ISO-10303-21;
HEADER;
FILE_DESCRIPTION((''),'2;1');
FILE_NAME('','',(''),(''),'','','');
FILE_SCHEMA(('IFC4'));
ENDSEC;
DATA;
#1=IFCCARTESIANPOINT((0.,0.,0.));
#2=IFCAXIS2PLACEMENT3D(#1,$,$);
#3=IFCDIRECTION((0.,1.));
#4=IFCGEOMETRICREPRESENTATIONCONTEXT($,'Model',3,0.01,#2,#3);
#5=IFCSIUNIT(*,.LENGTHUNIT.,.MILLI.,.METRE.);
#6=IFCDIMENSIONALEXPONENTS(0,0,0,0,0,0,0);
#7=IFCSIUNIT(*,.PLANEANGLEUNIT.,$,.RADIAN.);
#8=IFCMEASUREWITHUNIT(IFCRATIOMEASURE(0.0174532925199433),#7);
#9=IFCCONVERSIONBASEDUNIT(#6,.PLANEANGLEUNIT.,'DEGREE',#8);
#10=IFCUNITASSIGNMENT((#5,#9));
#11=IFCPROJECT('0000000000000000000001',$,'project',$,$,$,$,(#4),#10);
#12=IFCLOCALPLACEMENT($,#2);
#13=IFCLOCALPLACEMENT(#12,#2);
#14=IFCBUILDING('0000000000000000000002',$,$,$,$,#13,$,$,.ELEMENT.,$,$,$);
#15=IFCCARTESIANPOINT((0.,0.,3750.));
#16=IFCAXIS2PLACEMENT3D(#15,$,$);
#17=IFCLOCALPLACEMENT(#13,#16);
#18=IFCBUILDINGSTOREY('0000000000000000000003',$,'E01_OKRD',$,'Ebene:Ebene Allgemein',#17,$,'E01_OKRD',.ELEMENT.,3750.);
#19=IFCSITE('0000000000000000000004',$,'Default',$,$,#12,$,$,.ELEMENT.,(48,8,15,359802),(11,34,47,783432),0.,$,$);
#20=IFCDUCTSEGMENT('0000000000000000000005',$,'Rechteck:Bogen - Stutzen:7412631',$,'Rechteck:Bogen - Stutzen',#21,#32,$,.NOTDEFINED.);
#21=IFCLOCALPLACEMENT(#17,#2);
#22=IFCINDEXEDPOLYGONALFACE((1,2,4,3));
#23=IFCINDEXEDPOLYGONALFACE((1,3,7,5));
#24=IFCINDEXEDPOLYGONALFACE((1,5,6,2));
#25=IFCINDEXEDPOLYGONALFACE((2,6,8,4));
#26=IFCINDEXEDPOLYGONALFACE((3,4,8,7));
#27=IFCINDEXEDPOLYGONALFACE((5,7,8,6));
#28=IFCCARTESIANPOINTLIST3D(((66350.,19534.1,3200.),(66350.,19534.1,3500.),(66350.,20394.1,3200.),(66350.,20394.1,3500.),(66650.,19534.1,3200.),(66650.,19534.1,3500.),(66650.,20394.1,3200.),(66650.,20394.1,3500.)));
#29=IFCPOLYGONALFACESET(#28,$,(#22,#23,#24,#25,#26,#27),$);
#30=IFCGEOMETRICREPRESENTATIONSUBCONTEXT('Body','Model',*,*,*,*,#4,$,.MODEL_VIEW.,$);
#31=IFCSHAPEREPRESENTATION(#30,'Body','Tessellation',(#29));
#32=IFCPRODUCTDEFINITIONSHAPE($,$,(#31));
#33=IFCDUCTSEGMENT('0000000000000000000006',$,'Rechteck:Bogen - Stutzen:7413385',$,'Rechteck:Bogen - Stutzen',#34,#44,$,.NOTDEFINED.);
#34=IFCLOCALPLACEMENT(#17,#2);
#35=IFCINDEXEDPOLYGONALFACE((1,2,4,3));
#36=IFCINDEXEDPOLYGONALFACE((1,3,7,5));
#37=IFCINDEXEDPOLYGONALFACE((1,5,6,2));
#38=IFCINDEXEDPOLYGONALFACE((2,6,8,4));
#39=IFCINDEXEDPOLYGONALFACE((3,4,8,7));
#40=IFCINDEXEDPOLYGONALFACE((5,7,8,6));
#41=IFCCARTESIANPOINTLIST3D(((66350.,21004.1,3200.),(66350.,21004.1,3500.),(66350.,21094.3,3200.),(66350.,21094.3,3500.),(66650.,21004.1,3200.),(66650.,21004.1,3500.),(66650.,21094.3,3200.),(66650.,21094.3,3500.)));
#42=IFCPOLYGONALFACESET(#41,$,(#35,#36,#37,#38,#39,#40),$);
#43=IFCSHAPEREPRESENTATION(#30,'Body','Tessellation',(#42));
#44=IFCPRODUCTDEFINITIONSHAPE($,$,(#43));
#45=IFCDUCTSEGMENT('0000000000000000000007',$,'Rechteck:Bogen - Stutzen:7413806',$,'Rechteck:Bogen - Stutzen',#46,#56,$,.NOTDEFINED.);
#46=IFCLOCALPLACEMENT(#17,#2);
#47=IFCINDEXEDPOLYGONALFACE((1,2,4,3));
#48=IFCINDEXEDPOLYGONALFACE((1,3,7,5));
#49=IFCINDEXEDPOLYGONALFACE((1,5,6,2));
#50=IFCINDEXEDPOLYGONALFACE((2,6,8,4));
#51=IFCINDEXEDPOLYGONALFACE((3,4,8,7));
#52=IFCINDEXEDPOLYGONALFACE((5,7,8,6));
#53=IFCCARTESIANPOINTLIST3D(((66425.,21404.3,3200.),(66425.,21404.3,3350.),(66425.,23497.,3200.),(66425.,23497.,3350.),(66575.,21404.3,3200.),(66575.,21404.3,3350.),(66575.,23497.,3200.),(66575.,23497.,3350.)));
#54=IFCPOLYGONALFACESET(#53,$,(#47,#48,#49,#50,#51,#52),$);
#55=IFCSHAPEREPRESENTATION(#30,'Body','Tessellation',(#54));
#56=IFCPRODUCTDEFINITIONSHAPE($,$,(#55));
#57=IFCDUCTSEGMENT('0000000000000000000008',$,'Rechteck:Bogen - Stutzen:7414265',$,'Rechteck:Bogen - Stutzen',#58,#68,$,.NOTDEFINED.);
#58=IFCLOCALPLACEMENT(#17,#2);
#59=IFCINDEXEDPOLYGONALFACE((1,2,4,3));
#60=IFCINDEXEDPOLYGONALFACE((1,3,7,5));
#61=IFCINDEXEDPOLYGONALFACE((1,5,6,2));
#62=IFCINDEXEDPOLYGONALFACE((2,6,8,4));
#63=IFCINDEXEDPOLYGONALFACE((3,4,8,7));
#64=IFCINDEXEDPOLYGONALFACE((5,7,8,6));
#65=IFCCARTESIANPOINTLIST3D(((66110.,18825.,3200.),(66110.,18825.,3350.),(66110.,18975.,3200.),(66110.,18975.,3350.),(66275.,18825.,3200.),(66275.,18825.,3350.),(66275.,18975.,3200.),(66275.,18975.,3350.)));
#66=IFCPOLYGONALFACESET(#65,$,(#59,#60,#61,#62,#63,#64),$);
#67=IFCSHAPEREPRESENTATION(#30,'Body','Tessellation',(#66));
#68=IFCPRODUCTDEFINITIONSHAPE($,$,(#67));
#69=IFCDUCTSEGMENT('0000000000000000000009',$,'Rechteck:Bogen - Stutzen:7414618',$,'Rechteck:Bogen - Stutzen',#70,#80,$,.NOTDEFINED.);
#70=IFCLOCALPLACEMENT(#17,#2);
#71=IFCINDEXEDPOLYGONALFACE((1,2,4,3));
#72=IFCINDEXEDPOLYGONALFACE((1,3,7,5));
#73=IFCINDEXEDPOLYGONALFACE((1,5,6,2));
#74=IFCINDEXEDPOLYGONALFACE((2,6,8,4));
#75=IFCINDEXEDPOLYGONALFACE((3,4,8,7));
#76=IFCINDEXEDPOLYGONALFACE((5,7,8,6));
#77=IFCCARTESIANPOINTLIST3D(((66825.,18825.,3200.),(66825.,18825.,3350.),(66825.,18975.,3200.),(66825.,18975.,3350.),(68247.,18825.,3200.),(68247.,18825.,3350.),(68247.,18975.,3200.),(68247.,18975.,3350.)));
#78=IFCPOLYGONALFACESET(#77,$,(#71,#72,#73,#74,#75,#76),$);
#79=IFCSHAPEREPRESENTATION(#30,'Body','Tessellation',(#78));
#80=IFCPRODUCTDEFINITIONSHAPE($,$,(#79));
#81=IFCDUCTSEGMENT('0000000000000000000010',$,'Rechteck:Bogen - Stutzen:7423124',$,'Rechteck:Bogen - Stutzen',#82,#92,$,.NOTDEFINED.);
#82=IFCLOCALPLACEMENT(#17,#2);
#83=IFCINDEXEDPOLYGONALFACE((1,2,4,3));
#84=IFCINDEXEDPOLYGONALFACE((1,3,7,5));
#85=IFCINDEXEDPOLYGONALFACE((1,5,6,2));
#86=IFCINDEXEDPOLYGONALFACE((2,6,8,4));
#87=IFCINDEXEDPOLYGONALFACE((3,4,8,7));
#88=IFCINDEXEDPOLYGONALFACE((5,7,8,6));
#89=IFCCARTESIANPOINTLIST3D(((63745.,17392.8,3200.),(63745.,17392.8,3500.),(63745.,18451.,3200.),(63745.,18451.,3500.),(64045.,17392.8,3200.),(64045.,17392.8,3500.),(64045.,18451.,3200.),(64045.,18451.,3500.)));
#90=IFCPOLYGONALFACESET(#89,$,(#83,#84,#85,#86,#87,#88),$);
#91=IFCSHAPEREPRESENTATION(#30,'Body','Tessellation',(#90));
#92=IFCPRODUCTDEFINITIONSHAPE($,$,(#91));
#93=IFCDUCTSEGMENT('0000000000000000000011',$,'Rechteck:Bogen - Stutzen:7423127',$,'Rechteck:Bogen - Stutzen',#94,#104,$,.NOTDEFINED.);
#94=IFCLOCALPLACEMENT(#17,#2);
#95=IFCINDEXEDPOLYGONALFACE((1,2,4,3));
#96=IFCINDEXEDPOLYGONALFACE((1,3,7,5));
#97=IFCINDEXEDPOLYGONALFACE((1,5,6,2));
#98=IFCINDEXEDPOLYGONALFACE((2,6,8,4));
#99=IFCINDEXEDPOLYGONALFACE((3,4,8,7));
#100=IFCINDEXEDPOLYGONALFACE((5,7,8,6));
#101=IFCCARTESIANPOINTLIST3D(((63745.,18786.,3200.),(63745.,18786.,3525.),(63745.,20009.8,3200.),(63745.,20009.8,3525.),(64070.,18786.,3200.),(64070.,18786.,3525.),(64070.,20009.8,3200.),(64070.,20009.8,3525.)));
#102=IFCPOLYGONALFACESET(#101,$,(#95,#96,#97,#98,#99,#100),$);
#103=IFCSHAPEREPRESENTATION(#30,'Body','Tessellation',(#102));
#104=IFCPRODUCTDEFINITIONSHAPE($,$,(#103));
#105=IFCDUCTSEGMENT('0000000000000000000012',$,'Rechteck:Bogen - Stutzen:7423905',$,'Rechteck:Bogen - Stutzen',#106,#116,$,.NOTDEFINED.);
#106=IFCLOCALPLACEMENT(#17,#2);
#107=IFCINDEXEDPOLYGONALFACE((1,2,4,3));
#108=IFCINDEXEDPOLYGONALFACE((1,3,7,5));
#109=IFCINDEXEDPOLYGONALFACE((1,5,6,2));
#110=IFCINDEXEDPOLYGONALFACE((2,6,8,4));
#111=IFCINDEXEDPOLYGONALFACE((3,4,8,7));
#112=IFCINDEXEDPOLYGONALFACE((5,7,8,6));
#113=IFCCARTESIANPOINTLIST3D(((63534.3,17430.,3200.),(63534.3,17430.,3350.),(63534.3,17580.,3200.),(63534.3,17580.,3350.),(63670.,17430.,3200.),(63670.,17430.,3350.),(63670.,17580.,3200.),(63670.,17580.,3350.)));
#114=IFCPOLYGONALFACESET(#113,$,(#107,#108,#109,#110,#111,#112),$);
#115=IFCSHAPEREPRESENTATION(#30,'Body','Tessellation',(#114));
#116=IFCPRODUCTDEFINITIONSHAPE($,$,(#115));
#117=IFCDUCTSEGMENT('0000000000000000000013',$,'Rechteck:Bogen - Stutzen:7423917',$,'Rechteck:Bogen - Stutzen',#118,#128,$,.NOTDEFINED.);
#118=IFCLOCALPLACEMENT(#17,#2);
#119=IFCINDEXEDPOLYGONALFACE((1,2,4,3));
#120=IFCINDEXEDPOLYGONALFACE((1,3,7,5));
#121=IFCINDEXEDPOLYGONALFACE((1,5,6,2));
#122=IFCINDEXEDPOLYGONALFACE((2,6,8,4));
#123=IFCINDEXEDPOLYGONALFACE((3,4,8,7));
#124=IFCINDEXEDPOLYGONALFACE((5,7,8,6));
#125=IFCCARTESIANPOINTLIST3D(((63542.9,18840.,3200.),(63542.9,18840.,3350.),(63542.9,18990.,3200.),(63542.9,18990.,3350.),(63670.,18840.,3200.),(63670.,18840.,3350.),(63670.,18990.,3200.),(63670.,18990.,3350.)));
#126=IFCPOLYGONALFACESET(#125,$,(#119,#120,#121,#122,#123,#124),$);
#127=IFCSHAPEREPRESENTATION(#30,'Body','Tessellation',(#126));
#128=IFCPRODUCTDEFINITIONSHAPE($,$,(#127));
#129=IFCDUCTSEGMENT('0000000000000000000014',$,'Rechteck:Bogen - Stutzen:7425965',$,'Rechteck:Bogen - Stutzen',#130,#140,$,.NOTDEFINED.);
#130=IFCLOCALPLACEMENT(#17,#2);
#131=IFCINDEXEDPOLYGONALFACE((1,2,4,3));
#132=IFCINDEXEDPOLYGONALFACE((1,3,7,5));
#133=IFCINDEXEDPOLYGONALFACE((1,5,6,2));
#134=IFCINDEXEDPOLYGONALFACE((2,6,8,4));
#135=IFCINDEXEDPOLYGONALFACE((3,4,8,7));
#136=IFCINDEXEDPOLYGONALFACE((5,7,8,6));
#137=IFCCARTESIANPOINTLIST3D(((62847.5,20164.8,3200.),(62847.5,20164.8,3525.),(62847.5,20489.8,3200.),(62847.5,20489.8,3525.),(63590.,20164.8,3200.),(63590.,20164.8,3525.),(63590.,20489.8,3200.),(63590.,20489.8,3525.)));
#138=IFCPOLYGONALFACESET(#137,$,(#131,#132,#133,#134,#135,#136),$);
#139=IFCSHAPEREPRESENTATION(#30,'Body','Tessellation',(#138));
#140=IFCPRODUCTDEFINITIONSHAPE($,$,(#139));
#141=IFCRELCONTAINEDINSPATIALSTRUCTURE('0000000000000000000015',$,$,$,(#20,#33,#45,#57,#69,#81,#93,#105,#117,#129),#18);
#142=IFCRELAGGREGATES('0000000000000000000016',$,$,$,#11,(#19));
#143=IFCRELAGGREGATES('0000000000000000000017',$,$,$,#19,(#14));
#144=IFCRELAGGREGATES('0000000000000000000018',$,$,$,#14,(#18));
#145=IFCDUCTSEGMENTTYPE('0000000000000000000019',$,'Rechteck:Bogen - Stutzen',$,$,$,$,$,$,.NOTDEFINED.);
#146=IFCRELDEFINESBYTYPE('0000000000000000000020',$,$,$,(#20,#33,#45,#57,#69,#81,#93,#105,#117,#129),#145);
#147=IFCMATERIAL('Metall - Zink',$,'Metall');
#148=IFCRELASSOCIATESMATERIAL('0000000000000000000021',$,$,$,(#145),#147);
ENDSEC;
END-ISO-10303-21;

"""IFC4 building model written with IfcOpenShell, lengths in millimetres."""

from ifc_helpers import new_model, entity, si_unit, converted_unit, direction, frame, frame_2d, origin, origin_2d_with_axis, place, context, subcontext, project, spatial, rectangle, extrude, material, type_object, element, save


model = new_model("IFC4")

# Units and contexts
model_context = context("Model", 3, precision=0.01, world=origin(), true_north=direction((0.0, 1.0)))
body_context = subcontext(model_context, "Body", "Model", "MODEL_VIEW")
ifc_project = project(units=[si_unit("LENGTHUNIT", "METRE", prefix="MILLI"), converted_unit("PLANEANGLEUNIT", "DEGREE", entity("IfcRatioMeasure", 0.0174532925199433), si_unit("PLANEANGLEUNIT", "RADIAN"), dimensions=[0, 0, 0, 0, 0, 0, 0])], contexts=[model_context])

# Site, building, storey
site_placement = place(None, origin())
site = spatial("IfcSite", under=ifc_project, at=site_placement, Name="Default", CompositionType="ELEMENT", RefLatitude=(48, 8, 15, 359802), RefLongitude=(11, 34, 47, 783432), RefElevation=0.0)
building_placement = place(site_placement, origin())
building = spatial("IfcBuilding", under=site, at=building_placement, CompositionType="ELEMENT")
storey_placement = place(building_placement, frame((0.0, 0.0, 3750.0)))
storey = spatial("IfcBuildingStorey", under=building, at=storey_placement, Name="E01_OKRD", ObjectType="Ebene:Ebene Allgemein", LongName="E01_OKRD", CompositionType="ELEMENT", Elevation=3750.0)

# Duct segments
ifc_material_1 = material(Name="Metall - Zink", Category="Metall")
duct_segment_type_1 = type_object("IfcDuctSegmentType", Name="Rechteck:Bogen - Stutzen", PredefinedType="NOTDEFINED", material=ifc_material_1)
duct_segment_1_placement = place(storey_placement, frame((66350.0, 19534.1, 3200.0)))
element("IfcDuctSegment", 1, at=duct_segment_1_placement, inside=storey, type_object=duct_segment_type_1, Name="Rechteck:Bogen - Stutzen:7412631", ObjectType="Rechteck:Bogen - Stutzen", PredefinedType="NOTDEFINED", context=body_context, shape_type="SweptSolid", body=[
    extrude(rectangle(XDim=860.0, YDim=300.0, at=frame_2d((0.0, 0.0), x_axis=(1.0, 0.0))), frame((150.0, 430.0, 0.0), z_axis=(0.0, 0.0, 1.0), x_axis=(0.0, -1.0, 0.0)), (0.0, 0.0, 1.0), 300.0),
])
duct_segment_2_placement = place(storey_placement, frame((66350.0, 21004.1, 3200.0)))
element("IfcDuctSegment", 2, at=duct_segment_2_placement, inside=storey, type_object=duct_segment_type_1, Name="Rechteck:Bogen - Stutzen:7413385", ObjectType="Rechteck:Bogen - Stutzen", PredefinedType="NOTDEFINED", context=body_context, shape_type="SweptSolid", body=[
    extrude(rectangle(XDim=90.2, YDim=300.0, at=frame_2d((0.0, 0.0), x_axis=(1.0, 0.0))), frame((150.0, 45.1, 0.0), z_axis=(0.0, 0.0, 1.0), x_axis=(0.0, 1.0, 0.0)), (0.0, 0.0, 1.0), 300.0),
])
duct_segment_3_placement = place(storey_placement, frame((66425.0, 21404.3, 3200.0)))
element("IfcDuctSegment", 3, at=duct_segment_3_placement, inside=storey, type_object=duct_segment_type_1, Name="Rechteck:Bogen - Stutzen:7413806", ObjectType="Rechteck:Bogen - Stutzen", PredefinedType="NOTDEFINED", context=body_context, shape_type="SweptSolid", body=[
    extrude(rectangle(XDim=2092.7, YDim=150.0, at=frame_2d((0.0, 0.0), x_axis=(1.0, 0.0))), frame((75.0, 1046.4, 0.0), z_axis=(0.0, 0.0, 1.0), x_axis=(0.0, -1.0, 0.0)), (0.0, 0.0, 1.0), 150.0),
])
duct_segment_4_placement = place(storey_placement, frame((66110.0, 18825.0, 3200.0)))
element("IfcDuctSegment", 4, at=duct_segment_4_placement, inside=storey, type_object=duct_segment_type_1, Name="Rechteck:Bogen - Stutzen:7414265", ObjectType="Rechteck:Bogen - Stutzen", PredefinedType="NOTDEFINED", context=body_context, shape_type="SweptSolid", body=[
    extrude(rectangle(XDim=165.0, YDim=150.0, at=origin_2d_with_axis()), frame((82.5, 75.0, 0.0), z_axis=(0.0, 0.0, 1.0), x_axis=(-1.0, 0.0, 0.0)), (0.0, 0.0, 1.0), 150.0),
])
duct_segment_5_placement = place(storey_placement, frame((66825.0, 18825.0, 3200.0)))
element("IfcDuctSegment", 5, at=duct_segment_5_placement, inside=storey, type_object=duct_segment_type_1, Name="Rechteck:Bogen - Stutzen:7414618", ObjectType="Rechteck:Bogen - Stutzen", PredefinedType="NOTDEFINED", context=body_context, shape_type="SweptSolid", body=[
    extrude(rectangle(XDim=1422.0, YDim=150.0, at=frame_2d((0.0, 0.0), x_axis=(1.0, 0.0))), frame((711.0, 75.0, 0.0), z_axis=(-0.000013, 0.0, 1.0), x_axis=(-1.0, 0.0, -0.000013)), (0.0, 0.0, 1.0), 150.0),
])
duct_segment_6_placement = place(storey_placement, frame((63745.0, 17392.8, 3200.0)))
element("IfcDuctSegment", 6, at=duct_segment_6_placement, inside=storey, type_object=duct_segment_type_1, Name="Rechteck:Bogen - Stutzen:7423124", ObjectType="Rechteck:Bogen - Stutzen", PredefinedType="NOTDEFINED", context=body_context, shape_type="SweptSolid", body=[
    extrude(rectangle(XDim=1058.2, YDim=300.0, at=frame_2d((0.0, 0.0), x_axis=(1.0, 0.0))), frame((150.0, 529.1, 0.0), z_axis=(0.0, 0.0, 1.0), x_axis=(0.0, -1.0, 0.0)), (0.0, 0.0, 1.0), 300.0),
])
duct_segment_7_placement = place(storey_placement, frame((63745.0, 18786.0, 3200.0)))
element("IfcDuctSegment", 7, at=duct_segment_7_placement, inside=storey, type_object=duct_segment_type_1, Name="Rechteck:Bogen - Stutzen:7423127", ObjectType="Rechteck:Bogen - Stutzen", PredefinedType="NOTDEFINED", context=body_context, shape_type="SweptSolid", body=[
    extrude(rectangle(XDim=1223.8, YDim=325.0, at=frame_2d((0.0, 0.0), x_axis=(1.0, 0.0))), frame((162.5, 611.9, 0.0), z_axis=(0.0, 0.0, 1.0), x_axis=(0.0, 1.0, 0.0)), (0.0, 0.0, 1.0), 325.0),
])
duct_segment_8_placement = place(storey_placement, frame((63534.3, 17430.0, 3200.0)))
element("IfcDuctSegment", 8, at=duct_segment_8_placement, inside=storey, type_object=duct_segment_type_1, Name="Rechteck:Bogen - Stutzen:7423905", ObjectType="Rechteck:Bogen - Stutzen", PredefinedType="NOTDEFINED", context=body_context, shape_type="SweptSolid", body=[
    extrude(rectangle(XDim=135.7, YDim=150.0, at=origin_2d_with_axis()), frame((67.8, 75.0, 0.0)), (0.0, 0.0, 1.0), 150.0),
])
duct_segment_9_placement = place(storey_placement, frame((63542.9, 18840.0, 3200.0)))
element("IfcDuctSegment", 9, at=duct_segment_9_placement, inside=storey, type_object=duct_segment_type_1, Name="Rechteck:Bogen - Stutzen:7423917", ObjectType="Rechteck:Bogen - Stutzen", PredefinedType="NOTDEFINED", context=body_context, shape_type="SweptSolid", body=[
    extrude(rectangle(XDim=127.1, YDim=150.0, at=origin_2d_with_axis()), frame((63.5, 75.0, 0.0)), (0.0, 0.0, 1.0), 150.0),
])
duct_segment_10_placement = place(storey_placement, frame((62847.5, 20164.8, 3200.0)))
element("IfcDuctSegment", 10, at=duct_segment_10_placement, inside=storey, type_object=duct_segment_type_1, Name="Rechteck:Bogen - Stutzen:7425965", ObjectType="Rechteck:Bogen - Stutzen", PredefinedType="NOTDEFINED", context=body_context, shape_type="SweptSolid", body=[
    extrude(rectangle(XDim=742.5, YDim=325.0, at=frame_2d((0.0, 0.0), x_axis=(1.0, 0.0))), frame((371.3, 162.5, 0.0), z_axis=(0.0, 0.0, 1.0), x_axis=(-1.0, 0.0, 0.0)), (0.0, 0.0, 1.0), 325.0),
])

save(model, "model.ifc")
